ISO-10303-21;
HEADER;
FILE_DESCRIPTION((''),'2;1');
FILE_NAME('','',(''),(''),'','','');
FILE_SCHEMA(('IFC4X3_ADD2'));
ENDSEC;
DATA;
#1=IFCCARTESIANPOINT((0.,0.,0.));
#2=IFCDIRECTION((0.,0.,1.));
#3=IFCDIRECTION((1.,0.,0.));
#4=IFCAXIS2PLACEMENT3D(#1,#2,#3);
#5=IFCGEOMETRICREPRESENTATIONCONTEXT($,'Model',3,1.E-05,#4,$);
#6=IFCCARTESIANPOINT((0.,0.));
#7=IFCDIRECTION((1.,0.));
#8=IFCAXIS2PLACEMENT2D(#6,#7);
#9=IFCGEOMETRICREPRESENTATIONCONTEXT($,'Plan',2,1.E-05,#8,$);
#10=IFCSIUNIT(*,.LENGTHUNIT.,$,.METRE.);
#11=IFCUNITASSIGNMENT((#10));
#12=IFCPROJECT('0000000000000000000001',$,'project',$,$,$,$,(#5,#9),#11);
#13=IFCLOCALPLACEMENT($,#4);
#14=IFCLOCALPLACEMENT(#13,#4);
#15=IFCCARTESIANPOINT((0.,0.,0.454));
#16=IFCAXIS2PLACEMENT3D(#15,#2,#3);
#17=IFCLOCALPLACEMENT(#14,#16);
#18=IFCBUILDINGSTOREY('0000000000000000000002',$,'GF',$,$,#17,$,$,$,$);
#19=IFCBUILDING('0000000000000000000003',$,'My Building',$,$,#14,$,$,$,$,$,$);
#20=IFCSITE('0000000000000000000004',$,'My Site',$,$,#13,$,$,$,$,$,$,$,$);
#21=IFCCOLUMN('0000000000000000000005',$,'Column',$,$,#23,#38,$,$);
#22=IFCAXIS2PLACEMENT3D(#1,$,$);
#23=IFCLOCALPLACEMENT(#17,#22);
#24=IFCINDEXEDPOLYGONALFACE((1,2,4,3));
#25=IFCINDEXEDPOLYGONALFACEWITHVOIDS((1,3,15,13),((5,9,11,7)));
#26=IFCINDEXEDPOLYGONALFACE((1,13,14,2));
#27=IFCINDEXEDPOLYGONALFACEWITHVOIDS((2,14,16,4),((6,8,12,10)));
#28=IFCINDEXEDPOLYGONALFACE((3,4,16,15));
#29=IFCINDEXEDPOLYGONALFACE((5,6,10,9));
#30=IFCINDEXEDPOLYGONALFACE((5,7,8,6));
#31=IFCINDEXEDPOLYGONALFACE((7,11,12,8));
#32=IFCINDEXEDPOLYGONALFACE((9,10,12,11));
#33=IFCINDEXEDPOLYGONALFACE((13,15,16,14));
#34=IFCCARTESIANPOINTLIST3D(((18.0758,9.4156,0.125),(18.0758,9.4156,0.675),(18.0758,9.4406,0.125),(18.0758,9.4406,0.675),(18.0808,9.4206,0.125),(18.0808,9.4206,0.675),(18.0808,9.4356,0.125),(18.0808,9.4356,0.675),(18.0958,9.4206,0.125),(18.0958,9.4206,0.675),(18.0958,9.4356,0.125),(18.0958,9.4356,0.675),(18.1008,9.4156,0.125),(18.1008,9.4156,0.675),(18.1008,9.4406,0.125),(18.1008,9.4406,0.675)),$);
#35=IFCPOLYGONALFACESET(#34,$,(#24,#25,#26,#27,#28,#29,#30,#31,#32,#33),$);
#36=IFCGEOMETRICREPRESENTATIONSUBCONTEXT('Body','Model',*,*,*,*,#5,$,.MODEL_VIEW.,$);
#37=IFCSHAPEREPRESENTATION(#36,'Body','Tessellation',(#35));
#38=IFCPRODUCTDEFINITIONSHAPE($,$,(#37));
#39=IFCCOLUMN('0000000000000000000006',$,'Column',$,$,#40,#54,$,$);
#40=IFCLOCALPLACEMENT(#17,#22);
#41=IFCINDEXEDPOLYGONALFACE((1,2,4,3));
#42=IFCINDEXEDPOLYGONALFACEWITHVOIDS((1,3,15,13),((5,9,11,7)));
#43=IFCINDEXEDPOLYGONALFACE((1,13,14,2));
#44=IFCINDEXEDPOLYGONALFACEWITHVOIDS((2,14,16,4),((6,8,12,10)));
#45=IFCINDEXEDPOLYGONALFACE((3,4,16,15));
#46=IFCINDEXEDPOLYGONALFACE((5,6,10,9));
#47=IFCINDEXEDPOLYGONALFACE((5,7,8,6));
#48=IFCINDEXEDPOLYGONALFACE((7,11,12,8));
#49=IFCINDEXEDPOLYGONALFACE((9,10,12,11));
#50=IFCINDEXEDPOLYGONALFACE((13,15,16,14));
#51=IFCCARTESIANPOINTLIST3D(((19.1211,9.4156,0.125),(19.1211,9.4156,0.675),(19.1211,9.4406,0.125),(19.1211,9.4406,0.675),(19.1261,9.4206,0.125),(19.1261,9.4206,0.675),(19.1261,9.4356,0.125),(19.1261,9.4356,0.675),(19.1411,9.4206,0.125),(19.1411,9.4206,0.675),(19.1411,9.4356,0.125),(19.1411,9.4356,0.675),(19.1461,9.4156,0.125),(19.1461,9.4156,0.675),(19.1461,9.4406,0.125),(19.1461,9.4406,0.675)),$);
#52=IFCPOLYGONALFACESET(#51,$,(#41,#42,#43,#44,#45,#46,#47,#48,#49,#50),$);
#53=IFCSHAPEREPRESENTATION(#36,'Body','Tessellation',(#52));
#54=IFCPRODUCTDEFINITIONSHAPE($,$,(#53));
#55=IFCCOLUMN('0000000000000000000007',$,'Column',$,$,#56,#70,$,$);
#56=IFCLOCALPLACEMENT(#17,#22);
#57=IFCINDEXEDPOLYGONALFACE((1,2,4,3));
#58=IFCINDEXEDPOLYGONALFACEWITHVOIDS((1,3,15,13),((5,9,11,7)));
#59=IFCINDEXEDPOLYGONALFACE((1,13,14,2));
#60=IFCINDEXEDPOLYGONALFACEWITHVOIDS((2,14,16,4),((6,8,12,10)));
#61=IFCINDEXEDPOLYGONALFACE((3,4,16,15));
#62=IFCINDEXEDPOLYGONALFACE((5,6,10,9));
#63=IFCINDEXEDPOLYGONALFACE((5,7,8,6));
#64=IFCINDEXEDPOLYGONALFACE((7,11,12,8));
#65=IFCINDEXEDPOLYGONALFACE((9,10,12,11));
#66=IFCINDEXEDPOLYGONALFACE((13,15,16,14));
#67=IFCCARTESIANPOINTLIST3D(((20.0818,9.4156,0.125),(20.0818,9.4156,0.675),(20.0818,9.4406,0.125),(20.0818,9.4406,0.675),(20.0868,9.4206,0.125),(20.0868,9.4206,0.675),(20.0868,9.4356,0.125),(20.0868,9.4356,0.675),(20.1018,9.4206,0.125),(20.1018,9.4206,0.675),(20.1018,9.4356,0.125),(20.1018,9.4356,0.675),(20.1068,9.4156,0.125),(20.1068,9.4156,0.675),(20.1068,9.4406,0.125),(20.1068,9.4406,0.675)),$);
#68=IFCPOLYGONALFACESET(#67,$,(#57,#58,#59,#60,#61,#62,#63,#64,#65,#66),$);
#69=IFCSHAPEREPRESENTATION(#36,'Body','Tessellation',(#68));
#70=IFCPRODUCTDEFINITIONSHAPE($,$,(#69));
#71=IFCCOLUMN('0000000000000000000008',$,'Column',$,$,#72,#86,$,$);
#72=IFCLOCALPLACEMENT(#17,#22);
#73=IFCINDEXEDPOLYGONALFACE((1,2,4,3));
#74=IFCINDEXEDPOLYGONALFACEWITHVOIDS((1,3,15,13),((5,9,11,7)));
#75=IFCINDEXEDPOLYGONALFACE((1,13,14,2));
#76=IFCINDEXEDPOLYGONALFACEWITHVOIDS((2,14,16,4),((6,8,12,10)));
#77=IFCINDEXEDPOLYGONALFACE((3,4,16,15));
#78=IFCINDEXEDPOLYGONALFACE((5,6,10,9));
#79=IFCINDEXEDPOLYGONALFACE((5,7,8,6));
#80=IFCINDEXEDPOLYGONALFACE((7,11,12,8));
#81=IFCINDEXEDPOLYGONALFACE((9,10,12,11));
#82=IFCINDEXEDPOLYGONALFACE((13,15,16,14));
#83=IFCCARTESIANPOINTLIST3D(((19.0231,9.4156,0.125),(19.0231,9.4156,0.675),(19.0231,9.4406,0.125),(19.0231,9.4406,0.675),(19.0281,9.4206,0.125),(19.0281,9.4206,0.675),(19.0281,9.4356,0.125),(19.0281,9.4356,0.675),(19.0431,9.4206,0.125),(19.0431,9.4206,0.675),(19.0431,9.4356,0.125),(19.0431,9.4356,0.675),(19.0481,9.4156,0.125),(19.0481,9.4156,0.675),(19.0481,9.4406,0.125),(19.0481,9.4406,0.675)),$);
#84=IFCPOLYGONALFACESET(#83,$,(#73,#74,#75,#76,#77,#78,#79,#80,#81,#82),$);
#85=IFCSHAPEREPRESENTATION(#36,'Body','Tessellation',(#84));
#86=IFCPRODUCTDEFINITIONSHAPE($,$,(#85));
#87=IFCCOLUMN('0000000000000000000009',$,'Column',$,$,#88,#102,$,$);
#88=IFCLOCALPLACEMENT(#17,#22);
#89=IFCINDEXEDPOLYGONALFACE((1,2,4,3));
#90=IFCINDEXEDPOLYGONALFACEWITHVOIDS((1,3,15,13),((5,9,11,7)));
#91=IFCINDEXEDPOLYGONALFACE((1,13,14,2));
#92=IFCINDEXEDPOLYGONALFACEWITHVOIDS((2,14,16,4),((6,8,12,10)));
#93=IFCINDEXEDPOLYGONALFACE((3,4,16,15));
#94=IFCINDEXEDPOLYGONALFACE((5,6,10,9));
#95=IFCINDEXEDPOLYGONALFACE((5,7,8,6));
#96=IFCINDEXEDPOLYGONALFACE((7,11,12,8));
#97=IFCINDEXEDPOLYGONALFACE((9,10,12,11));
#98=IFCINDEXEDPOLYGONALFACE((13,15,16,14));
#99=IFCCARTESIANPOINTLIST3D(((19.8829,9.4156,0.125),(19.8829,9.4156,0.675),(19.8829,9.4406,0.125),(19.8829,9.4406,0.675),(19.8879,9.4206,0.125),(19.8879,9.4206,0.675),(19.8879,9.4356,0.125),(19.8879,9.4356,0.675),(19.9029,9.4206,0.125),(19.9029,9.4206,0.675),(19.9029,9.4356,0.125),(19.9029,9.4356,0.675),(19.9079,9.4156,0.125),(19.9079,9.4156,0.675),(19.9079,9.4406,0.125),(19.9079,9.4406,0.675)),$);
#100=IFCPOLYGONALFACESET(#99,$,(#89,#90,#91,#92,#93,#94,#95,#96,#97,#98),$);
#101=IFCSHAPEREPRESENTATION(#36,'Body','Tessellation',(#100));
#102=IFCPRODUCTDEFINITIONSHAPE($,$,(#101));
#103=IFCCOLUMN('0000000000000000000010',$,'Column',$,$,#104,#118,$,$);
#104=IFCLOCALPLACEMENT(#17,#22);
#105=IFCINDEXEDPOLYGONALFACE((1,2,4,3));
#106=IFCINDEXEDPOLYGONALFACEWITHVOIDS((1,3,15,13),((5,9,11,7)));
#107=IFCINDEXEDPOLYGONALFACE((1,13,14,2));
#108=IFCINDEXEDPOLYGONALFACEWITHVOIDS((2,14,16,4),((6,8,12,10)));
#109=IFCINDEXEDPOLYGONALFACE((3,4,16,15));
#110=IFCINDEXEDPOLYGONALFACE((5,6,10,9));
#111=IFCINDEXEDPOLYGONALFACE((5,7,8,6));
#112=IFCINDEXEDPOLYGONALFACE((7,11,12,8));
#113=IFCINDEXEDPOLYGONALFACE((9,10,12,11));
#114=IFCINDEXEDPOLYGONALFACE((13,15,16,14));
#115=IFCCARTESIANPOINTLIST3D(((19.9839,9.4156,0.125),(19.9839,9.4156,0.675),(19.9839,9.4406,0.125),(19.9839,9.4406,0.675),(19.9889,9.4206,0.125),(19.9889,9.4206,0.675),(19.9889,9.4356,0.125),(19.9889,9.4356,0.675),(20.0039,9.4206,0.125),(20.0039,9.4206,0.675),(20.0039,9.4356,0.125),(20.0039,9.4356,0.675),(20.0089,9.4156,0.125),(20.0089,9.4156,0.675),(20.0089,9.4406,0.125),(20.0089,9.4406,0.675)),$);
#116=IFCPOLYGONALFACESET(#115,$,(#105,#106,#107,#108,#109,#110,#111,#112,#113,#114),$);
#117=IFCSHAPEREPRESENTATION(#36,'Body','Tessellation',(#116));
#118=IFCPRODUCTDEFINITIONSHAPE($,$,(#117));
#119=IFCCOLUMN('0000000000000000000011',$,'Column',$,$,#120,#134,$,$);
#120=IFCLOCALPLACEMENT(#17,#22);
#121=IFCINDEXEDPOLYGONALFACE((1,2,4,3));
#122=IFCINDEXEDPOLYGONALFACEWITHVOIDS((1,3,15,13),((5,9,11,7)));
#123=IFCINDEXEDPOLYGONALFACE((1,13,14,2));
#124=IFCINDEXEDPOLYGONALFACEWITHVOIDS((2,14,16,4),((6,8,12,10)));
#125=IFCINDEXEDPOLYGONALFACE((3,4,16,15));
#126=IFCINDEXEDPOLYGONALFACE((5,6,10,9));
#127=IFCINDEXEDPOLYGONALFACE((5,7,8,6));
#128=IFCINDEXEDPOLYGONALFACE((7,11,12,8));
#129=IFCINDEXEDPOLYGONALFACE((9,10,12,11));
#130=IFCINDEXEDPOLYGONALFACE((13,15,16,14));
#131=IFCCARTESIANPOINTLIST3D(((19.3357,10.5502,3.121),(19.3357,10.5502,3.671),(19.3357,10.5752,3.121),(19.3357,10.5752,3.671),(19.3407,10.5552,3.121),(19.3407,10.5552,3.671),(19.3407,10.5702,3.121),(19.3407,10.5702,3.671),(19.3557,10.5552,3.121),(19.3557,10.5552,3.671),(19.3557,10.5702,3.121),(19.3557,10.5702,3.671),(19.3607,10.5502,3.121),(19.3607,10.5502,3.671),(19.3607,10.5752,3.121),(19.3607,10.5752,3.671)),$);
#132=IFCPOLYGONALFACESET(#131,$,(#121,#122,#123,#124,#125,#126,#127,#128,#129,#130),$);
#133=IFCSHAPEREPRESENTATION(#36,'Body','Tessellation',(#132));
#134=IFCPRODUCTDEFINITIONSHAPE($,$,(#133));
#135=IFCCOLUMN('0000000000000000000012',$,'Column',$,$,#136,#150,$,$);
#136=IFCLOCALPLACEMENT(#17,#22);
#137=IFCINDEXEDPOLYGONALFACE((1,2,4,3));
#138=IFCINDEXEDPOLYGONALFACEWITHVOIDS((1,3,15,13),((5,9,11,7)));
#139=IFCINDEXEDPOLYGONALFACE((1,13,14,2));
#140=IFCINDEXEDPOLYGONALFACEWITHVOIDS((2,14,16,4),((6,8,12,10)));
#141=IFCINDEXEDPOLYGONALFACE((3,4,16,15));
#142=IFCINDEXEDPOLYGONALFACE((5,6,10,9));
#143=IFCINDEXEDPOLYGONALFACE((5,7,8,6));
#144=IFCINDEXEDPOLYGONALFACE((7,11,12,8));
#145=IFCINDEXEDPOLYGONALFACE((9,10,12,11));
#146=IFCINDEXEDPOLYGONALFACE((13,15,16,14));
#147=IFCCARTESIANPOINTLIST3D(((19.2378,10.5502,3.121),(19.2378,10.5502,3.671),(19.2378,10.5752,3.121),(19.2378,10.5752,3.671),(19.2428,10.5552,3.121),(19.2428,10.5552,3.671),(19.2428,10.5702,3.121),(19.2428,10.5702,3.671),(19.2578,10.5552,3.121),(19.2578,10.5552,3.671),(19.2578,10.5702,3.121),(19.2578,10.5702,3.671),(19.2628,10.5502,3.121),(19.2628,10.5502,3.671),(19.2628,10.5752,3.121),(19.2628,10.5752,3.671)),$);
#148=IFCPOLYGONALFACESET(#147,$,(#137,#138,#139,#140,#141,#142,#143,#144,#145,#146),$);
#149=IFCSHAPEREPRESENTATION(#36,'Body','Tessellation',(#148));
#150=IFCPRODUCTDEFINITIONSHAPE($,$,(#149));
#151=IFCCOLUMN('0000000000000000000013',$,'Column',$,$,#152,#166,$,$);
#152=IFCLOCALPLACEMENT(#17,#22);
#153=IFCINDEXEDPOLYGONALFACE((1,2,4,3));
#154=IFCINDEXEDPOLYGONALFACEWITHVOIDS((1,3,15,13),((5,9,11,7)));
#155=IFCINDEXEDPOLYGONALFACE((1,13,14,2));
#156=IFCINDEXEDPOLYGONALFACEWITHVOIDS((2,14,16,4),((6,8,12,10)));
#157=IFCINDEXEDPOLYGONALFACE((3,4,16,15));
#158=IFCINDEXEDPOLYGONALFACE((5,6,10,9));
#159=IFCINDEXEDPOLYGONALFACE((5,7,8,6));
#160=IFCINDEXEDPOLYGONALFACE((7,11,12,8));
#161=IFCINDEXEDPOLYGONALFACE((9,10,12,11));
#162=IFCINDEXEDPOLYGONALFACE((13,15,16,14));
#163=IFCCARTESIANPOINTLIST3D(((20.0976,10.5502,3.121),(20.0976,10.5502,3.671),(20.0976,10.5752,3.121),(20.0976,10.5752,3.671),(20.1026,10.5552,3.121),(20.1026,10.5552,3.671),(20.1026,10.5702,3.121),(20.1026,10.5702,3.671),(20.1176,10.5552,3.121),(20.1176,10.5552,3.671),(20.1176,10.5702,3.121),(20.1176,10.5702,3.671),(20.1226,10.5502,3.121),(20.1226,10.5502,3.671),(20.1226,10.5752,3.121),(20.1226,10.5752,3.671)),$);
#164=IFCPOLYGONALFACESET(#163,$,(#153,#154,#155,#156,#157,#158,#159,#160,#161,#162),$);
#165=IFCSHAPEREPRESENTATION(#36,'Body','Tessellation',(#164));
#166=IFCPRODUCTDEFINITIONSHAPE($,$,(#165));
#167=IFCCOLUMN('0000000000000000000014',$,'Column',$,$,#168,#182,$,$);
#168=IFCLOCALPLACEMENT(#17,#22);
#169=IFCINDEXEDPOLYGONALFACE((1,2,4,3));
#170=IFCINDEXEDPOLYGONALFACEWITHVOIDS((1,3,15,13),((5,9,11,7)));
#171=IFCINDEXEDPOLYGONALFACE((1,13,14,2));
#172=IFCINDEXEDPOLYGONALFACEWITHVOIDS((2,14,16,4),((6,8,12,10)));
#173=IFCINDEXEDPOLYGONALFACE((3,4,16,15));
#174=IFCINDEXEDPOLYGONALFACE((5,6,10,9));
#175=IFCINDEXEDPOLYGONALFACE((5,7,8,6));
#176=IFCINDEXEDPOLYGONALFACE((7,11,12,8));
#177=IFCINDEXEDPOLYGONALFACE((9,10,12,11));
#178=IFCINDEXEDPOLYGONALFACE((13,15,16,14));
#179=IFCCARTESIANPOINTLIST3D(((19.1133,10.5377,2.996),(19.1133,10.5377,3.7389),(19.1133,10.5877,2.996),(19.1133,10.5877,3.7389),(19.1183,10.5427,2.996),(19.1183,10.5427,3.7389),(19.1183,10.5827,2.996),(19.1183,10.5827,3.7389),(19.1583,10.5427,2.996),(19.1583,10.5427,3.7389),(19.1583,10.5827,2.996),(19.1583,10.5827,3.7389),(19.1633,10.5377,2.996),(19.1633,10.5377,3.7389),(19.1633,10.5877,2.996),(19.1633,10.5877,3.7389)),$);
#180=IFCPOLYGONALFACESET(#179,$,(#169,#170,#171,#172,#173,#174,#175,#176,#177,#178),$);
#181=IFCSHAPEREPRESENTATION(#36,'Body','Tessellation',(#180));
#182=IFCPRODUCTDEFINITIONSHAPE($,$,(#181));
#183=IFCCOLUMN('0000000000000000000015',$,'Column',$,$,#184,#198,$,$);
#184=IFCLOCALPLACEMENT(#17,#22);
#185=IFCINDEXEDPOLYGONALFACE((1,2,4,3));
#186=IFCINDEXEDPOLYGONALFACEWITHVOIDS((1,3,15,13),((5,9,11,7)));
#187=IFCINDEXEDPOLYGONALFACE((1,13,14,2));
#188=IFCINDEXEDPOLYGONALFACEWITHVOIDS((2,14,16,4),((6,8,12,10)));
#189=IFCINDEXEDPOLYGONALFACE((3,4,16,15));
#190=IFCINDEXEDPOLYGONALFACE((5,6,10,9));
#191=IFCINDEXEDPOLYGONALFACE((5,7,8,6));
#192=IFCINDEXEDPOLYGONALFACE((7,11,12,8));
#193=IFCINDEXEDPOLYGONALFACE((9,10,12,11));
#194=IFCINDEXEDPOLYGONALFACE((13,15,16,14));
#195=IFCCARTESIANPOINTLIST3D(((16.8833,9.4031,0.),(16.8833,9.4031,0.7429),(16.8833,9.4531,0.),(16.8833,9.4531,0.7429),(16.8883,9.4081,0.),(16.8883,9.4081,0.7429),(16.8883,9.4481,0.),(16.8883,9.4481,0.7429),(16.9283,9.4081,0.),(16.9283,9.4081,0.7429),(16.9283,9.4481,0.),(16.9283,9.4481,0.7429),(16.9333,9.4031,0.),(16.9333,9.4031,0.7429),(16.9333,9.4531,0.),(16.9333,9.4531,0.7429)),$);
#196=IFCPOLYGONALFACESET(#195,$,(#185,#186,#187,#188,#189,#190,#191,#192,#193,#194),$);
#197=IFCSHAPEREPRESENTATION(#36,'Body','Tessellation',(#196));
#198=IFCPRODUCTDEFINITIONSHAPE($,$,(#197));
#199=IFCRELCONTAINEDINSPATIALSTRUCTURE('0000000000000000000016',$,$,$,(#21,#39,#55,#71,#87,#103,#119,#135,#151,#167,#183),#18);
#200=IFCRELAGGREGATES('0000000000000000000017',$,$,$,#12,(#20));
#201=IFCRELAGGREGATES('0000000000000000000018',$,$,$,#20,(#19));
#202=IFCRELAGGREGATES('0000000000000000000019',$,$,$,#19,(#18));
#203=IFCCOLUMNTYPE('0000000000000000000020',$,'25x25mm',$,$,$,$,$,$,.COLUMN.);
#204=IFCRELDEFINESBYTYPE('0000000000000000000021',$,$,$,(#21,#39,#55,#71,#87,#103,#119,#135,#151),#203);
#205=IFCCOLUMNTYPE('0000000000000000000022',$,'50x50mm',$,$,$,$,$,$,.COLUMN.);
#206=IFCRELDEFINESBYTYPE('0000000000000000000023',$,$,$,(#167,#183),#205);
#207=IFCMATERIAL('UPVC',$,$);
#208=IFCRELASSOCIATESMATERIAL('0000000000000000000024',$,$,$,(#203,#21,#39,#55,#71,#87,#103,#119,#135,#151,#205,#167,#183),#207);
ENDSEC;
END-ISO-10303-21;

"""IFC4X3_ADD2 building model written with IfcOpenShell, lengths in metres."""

from ifc_helpers import new_model, si_unit, frame, origin_with_axes, origin_2d_with_axis, place, context, subcontext, project, spatial, hollow_rectangle, extrude, material, material_profile, profile_set, profile_usage, type_object, element, save


model = new_model("IFC4X3_ADD2")

# Units and contexts
model_context = context("Model", 3, precision=1e-05, world=origin_with_axes())
plan_context = context("Plan", 2, precision=1e-05, world=origin_2d_with_axis())
body_context = subcontext(model_context, "Body", "Model", "MODEL_VIEW")
ifc_project = project(units=[si_unit("LENGTHUNIT", "METRE")], contexts=[model_context, plan_context])

# Site, building, storey
site_placement = place(None, origin_with_axes())
site = spatial("IfcSite", under=ifc_project, at=site_placement, Name="My Site")
building_placement = place(site_placement, origin_with_axes())
building = spatial("IfcBuilding", under=site, at=building_placement, Name="My Building")
storey_placement = place(building_placement, frame((0.0, 0.0, 0.454), z_axis=(0.0, 0.0, 1.0), x_axis=(1.0, 0.0, 0.0)))
storey = spatial("IfcBuildingStorey", under=building, at=storey_placement, Name="GF")

# Columns
ifc_material = material(Name="UPVC")
ifc_material_profile_1 = material_profile(ifc_material, hollow_rectangle(XDim=0.025, YDim=0.025, WallThickness=0.005))
ifc_profile_set_1 = profile_set([ifc_material_profile_1])
column_type_1 = type_object("IfcColumnType", Name="25x25mm", PredefinedType="COLUMN", material=ifc_profile_set_1)
ifc_profile_usage_1 = profile_usage(ifc_profile_set_1)
column_1_placement = place(storey_placement, frame((18.0883, 9.4281, 0.125), z_axis=(0.0, 0.0, 1.0), x_axis=(0.0, -1.0, 0.0)))
element("IfcColumn", 1, at=column_1_placement, inside=storey, type_object=column_type_1, material=ifc_profile_usage_1, Name="Column", context=body_context, shape_type="SweptSolid", body=[
    extrude(hollow_rectangle(XDim=0.025, YDim=0.025, WallThickness=0.005), origin_with_axes(), (0.0, 0.0, 1.0), 0.55),
])
ifc_profile_usage_2 = profile_usage(ifc_profile_set_1)
column_2_placement = place(storey_placement, frame((19.1336, 9.4281, 0.125), z_axis=(0.0, 0.0, 1.0), x_axis=(0.0, -1.0, 0.0)))
element("IfcColumn", 2, at=column_2_placement, inside=storey, type_object=column_type_1, material=ifc_profile_usage_2, Name="Column", context=body_context, shape_type="SweptSolid", body=[
    extrude(hollow_rectangle(XDim=0.025, YDim=0.025, WallThickness=0.005), origin_with_axes(), (0.0, 0.0, 1.0), 0.55),
])
ifc_profile_usage_3 = profile_usage(ifc_profile_set_1)
column_3_placement = place(storey_placement, frame((20.0943, 9.4281, 0.125), z_axis=(0.0, 0.0, 1.0), x_axis=(0.0, -1.0, 0.0)))
element("IfcColumn", 3, at=column_3_placement, inside=storey, type_object=column_type_1, material=ifc_profile_usage_3, Name="Column", context=body_context, shape_type="SweptSolid", body=[
    extrude(hollow_rectangle(XDim=0.025, YDim=0.025, WallThickness=0.005), origin_with_axes(), (0.0, 0.0, 1.0), 0.55),
])
ifc_profile_usage_4 = profile_usage(ifc_profile_set_1)
column_4_placement = place(storey_placement, frame((19.0356, 9.4281, 0.125), z_axis=(0.0, 0.0, 1.0), x_axis=(0.0, -1.0, 0.0)))
element("IfcColumn", 4, at=column_4_placement, inside=storey, type_object=column_type_1, material=ifc_profile_usage_4, Name="Column", context=body_context, shape_type="SweptSolid", body=[
    extrude(hollow_rectangle(XDim=0.025, YDim=0.025, WallThickness=0.005), origin_with_axes(), (0.0, 0.0, 1.0), 0.55),
])
ifc_profile_usage_5 = profile_usage(ifc_profile_set_1)
column_5_placement = place(storey_placement, frame((19.8954, 9.4281, 0.125), z_axis=(0.0, 0.0, 1.0), x_axis=(0.0, -1.0, 0.0)))
element("IfcColumn", 5, at=column_5_placement, inside=storey, type_object=column_type_1, material=ifc_profile_usage_5, Name="Column", context=body_context, shape_type="SweptSolid", body=[
    extrude(hollow_rectangle(XDim=0.025, YDim=0.025, WallThickness=0.005), origin_with_axes(), (0.0, 0.0, 1.0), 0.55),
])
ifc_profile_usage_6 = profile_usage(ifc_profile_set_1)
column_6_placement = place(storey_placement, frame((19.9964, 9.4281, 0.125), z_axis=(0.0, 0.0, 1.0), x_axis=(0.0, -1.0, 0.0)))
element("IfcColumn", 6, at=column_6_placement, inside=storey, type_object=column_type_1, material=ifc_profile_usage_6, Name="Column", context=body_context, shape_type="SweptSolid", body=[
    extrude(hollow_rectangle(XDim=0.025, YDim=0.025, WallThickness=0.005), origin_with_axes(), (0.0, 0.0, 1.0), 0.55),
])
ifc_profile_usage_7 = profile_usage(ifc_profile_set_1)
column_7_placement = place(storey_placement, frame((19.3482, 10.5627, 3.121), z_axis=(0.0, 0.0, 1.0), x_axis=(0.0, -1.0, 0.0)))
element("IfcColumn", 7, at=column_7_placement, inside=storey, type_object=column_type_1, material=ifc_profile_usage_7, Name="Column", context=body_context, shape_type="SweptSolid", body=[
    extrude(hollow_rectangle(XDim=0.025, YDim=0.025, WallThickness=0.005), origin_with_axes(), (0.0, 0.0, 1.0), 0.55),
])
ifc_profile_usage_8 = profile_usage(ifc_profile_set_1)
column_8_placement = place(storey_placement, frame((19.2503, 10.5627, 3.121), z_axis=(0.0, 0.0, 1.0), x_axis=(0.0, -1.0, 0.0)))
element("IfcColumn", 8, at=column_8_placement, inside=storey, type_object=column_type_1, material=ifc_profile_usage_8, Name="Column", context=body_context, shape_type="SweptSolid", body=[
    extrude(hollow_rectangle(XDim=0.025, YDim=0.025, WallThickness=0.005), origin_with_axes(), (0.0, 0.0, 1.0), 0.55),
])
ifc_profile_usage_9 = profile_usage(ifc_profile_set_1)
column_9_placement = place(storey_placement, frame((20.1101, 10.5627, 3.121), z_axis=(0.0, 0.0, 1.0), x_axis=(0.0, -1.0, 0.0)))
element("IfcColumn", 9, at=column_9_placement, inside=storey, type_object=column_type_1, material=ifc_profile_usage_9, Name="Column", context=body_context, shape_type="SweptSolid", body=[
    extrude(hollow_rectangle(XDim=0.025, YDim=0.025, WallThickness=0.005), origin_with_axes(), (0.0, 0.0, 1.0), 0.55),
])
ifc_material_profile_2 = material_profile(ifc_material, hollow_rectangle(XDim=0.05, YDim=0.05, WallThickness=0.005))
ifc_profile_set_2 = profile_set([ifc_material_profile_2])
ifc_profile_usage_10 = profile_usage(ifc_profile_set_2)
column_type_2 = type_object("IfcColumnType", Name="50x50mm", PredefinedType="COLUMN", material=ifc_profile_set_2)
column_10_placement = place(storey_placement, frame((19.1383, 10.5627, 2.996), z_axis=(0.0, 0.0, 1.0), x_axis=(1.0, 0.0, 0.0)))
element("IfcColumn", 10, at=column_10_placement, inside=storey, type_object=column_type_2, material=ifc_profile_usage_10, Name="Column", context=body_context, shape_type="SweptSolid", body=[
    extrude(hollow_rectangle(XDim=0.05, YDim=0.05, WallThickness=0.005), origin_with_axes(), (0.0, 0.0, 1.0), 0.7429),
])
ifc_profile_usage_11 = profile_usage(ifc_profile_set_2)
column_11_placement = place(storey_placement, frame((16.9083, 9.4281, 0.0), z_axis=(0.0, 0.0, 1.0), x_axis=(1.0, 0.0, 0.0)))
element("IfcColumn", 11, at=column_11_placement, inside=storey, type_object=column_type_2, material=ifc_profile_usage_11, Name="Column", context=body_context, shape_type="SweptSolid", body=[
    extrude(hollow_rectangle(XDim=0.05, YDim=0.05, WallThickness=0.005), origin_with_axes(), (0.0, 0.0, 1.0), 0.7429),
])

save(model, "model.ifc")
